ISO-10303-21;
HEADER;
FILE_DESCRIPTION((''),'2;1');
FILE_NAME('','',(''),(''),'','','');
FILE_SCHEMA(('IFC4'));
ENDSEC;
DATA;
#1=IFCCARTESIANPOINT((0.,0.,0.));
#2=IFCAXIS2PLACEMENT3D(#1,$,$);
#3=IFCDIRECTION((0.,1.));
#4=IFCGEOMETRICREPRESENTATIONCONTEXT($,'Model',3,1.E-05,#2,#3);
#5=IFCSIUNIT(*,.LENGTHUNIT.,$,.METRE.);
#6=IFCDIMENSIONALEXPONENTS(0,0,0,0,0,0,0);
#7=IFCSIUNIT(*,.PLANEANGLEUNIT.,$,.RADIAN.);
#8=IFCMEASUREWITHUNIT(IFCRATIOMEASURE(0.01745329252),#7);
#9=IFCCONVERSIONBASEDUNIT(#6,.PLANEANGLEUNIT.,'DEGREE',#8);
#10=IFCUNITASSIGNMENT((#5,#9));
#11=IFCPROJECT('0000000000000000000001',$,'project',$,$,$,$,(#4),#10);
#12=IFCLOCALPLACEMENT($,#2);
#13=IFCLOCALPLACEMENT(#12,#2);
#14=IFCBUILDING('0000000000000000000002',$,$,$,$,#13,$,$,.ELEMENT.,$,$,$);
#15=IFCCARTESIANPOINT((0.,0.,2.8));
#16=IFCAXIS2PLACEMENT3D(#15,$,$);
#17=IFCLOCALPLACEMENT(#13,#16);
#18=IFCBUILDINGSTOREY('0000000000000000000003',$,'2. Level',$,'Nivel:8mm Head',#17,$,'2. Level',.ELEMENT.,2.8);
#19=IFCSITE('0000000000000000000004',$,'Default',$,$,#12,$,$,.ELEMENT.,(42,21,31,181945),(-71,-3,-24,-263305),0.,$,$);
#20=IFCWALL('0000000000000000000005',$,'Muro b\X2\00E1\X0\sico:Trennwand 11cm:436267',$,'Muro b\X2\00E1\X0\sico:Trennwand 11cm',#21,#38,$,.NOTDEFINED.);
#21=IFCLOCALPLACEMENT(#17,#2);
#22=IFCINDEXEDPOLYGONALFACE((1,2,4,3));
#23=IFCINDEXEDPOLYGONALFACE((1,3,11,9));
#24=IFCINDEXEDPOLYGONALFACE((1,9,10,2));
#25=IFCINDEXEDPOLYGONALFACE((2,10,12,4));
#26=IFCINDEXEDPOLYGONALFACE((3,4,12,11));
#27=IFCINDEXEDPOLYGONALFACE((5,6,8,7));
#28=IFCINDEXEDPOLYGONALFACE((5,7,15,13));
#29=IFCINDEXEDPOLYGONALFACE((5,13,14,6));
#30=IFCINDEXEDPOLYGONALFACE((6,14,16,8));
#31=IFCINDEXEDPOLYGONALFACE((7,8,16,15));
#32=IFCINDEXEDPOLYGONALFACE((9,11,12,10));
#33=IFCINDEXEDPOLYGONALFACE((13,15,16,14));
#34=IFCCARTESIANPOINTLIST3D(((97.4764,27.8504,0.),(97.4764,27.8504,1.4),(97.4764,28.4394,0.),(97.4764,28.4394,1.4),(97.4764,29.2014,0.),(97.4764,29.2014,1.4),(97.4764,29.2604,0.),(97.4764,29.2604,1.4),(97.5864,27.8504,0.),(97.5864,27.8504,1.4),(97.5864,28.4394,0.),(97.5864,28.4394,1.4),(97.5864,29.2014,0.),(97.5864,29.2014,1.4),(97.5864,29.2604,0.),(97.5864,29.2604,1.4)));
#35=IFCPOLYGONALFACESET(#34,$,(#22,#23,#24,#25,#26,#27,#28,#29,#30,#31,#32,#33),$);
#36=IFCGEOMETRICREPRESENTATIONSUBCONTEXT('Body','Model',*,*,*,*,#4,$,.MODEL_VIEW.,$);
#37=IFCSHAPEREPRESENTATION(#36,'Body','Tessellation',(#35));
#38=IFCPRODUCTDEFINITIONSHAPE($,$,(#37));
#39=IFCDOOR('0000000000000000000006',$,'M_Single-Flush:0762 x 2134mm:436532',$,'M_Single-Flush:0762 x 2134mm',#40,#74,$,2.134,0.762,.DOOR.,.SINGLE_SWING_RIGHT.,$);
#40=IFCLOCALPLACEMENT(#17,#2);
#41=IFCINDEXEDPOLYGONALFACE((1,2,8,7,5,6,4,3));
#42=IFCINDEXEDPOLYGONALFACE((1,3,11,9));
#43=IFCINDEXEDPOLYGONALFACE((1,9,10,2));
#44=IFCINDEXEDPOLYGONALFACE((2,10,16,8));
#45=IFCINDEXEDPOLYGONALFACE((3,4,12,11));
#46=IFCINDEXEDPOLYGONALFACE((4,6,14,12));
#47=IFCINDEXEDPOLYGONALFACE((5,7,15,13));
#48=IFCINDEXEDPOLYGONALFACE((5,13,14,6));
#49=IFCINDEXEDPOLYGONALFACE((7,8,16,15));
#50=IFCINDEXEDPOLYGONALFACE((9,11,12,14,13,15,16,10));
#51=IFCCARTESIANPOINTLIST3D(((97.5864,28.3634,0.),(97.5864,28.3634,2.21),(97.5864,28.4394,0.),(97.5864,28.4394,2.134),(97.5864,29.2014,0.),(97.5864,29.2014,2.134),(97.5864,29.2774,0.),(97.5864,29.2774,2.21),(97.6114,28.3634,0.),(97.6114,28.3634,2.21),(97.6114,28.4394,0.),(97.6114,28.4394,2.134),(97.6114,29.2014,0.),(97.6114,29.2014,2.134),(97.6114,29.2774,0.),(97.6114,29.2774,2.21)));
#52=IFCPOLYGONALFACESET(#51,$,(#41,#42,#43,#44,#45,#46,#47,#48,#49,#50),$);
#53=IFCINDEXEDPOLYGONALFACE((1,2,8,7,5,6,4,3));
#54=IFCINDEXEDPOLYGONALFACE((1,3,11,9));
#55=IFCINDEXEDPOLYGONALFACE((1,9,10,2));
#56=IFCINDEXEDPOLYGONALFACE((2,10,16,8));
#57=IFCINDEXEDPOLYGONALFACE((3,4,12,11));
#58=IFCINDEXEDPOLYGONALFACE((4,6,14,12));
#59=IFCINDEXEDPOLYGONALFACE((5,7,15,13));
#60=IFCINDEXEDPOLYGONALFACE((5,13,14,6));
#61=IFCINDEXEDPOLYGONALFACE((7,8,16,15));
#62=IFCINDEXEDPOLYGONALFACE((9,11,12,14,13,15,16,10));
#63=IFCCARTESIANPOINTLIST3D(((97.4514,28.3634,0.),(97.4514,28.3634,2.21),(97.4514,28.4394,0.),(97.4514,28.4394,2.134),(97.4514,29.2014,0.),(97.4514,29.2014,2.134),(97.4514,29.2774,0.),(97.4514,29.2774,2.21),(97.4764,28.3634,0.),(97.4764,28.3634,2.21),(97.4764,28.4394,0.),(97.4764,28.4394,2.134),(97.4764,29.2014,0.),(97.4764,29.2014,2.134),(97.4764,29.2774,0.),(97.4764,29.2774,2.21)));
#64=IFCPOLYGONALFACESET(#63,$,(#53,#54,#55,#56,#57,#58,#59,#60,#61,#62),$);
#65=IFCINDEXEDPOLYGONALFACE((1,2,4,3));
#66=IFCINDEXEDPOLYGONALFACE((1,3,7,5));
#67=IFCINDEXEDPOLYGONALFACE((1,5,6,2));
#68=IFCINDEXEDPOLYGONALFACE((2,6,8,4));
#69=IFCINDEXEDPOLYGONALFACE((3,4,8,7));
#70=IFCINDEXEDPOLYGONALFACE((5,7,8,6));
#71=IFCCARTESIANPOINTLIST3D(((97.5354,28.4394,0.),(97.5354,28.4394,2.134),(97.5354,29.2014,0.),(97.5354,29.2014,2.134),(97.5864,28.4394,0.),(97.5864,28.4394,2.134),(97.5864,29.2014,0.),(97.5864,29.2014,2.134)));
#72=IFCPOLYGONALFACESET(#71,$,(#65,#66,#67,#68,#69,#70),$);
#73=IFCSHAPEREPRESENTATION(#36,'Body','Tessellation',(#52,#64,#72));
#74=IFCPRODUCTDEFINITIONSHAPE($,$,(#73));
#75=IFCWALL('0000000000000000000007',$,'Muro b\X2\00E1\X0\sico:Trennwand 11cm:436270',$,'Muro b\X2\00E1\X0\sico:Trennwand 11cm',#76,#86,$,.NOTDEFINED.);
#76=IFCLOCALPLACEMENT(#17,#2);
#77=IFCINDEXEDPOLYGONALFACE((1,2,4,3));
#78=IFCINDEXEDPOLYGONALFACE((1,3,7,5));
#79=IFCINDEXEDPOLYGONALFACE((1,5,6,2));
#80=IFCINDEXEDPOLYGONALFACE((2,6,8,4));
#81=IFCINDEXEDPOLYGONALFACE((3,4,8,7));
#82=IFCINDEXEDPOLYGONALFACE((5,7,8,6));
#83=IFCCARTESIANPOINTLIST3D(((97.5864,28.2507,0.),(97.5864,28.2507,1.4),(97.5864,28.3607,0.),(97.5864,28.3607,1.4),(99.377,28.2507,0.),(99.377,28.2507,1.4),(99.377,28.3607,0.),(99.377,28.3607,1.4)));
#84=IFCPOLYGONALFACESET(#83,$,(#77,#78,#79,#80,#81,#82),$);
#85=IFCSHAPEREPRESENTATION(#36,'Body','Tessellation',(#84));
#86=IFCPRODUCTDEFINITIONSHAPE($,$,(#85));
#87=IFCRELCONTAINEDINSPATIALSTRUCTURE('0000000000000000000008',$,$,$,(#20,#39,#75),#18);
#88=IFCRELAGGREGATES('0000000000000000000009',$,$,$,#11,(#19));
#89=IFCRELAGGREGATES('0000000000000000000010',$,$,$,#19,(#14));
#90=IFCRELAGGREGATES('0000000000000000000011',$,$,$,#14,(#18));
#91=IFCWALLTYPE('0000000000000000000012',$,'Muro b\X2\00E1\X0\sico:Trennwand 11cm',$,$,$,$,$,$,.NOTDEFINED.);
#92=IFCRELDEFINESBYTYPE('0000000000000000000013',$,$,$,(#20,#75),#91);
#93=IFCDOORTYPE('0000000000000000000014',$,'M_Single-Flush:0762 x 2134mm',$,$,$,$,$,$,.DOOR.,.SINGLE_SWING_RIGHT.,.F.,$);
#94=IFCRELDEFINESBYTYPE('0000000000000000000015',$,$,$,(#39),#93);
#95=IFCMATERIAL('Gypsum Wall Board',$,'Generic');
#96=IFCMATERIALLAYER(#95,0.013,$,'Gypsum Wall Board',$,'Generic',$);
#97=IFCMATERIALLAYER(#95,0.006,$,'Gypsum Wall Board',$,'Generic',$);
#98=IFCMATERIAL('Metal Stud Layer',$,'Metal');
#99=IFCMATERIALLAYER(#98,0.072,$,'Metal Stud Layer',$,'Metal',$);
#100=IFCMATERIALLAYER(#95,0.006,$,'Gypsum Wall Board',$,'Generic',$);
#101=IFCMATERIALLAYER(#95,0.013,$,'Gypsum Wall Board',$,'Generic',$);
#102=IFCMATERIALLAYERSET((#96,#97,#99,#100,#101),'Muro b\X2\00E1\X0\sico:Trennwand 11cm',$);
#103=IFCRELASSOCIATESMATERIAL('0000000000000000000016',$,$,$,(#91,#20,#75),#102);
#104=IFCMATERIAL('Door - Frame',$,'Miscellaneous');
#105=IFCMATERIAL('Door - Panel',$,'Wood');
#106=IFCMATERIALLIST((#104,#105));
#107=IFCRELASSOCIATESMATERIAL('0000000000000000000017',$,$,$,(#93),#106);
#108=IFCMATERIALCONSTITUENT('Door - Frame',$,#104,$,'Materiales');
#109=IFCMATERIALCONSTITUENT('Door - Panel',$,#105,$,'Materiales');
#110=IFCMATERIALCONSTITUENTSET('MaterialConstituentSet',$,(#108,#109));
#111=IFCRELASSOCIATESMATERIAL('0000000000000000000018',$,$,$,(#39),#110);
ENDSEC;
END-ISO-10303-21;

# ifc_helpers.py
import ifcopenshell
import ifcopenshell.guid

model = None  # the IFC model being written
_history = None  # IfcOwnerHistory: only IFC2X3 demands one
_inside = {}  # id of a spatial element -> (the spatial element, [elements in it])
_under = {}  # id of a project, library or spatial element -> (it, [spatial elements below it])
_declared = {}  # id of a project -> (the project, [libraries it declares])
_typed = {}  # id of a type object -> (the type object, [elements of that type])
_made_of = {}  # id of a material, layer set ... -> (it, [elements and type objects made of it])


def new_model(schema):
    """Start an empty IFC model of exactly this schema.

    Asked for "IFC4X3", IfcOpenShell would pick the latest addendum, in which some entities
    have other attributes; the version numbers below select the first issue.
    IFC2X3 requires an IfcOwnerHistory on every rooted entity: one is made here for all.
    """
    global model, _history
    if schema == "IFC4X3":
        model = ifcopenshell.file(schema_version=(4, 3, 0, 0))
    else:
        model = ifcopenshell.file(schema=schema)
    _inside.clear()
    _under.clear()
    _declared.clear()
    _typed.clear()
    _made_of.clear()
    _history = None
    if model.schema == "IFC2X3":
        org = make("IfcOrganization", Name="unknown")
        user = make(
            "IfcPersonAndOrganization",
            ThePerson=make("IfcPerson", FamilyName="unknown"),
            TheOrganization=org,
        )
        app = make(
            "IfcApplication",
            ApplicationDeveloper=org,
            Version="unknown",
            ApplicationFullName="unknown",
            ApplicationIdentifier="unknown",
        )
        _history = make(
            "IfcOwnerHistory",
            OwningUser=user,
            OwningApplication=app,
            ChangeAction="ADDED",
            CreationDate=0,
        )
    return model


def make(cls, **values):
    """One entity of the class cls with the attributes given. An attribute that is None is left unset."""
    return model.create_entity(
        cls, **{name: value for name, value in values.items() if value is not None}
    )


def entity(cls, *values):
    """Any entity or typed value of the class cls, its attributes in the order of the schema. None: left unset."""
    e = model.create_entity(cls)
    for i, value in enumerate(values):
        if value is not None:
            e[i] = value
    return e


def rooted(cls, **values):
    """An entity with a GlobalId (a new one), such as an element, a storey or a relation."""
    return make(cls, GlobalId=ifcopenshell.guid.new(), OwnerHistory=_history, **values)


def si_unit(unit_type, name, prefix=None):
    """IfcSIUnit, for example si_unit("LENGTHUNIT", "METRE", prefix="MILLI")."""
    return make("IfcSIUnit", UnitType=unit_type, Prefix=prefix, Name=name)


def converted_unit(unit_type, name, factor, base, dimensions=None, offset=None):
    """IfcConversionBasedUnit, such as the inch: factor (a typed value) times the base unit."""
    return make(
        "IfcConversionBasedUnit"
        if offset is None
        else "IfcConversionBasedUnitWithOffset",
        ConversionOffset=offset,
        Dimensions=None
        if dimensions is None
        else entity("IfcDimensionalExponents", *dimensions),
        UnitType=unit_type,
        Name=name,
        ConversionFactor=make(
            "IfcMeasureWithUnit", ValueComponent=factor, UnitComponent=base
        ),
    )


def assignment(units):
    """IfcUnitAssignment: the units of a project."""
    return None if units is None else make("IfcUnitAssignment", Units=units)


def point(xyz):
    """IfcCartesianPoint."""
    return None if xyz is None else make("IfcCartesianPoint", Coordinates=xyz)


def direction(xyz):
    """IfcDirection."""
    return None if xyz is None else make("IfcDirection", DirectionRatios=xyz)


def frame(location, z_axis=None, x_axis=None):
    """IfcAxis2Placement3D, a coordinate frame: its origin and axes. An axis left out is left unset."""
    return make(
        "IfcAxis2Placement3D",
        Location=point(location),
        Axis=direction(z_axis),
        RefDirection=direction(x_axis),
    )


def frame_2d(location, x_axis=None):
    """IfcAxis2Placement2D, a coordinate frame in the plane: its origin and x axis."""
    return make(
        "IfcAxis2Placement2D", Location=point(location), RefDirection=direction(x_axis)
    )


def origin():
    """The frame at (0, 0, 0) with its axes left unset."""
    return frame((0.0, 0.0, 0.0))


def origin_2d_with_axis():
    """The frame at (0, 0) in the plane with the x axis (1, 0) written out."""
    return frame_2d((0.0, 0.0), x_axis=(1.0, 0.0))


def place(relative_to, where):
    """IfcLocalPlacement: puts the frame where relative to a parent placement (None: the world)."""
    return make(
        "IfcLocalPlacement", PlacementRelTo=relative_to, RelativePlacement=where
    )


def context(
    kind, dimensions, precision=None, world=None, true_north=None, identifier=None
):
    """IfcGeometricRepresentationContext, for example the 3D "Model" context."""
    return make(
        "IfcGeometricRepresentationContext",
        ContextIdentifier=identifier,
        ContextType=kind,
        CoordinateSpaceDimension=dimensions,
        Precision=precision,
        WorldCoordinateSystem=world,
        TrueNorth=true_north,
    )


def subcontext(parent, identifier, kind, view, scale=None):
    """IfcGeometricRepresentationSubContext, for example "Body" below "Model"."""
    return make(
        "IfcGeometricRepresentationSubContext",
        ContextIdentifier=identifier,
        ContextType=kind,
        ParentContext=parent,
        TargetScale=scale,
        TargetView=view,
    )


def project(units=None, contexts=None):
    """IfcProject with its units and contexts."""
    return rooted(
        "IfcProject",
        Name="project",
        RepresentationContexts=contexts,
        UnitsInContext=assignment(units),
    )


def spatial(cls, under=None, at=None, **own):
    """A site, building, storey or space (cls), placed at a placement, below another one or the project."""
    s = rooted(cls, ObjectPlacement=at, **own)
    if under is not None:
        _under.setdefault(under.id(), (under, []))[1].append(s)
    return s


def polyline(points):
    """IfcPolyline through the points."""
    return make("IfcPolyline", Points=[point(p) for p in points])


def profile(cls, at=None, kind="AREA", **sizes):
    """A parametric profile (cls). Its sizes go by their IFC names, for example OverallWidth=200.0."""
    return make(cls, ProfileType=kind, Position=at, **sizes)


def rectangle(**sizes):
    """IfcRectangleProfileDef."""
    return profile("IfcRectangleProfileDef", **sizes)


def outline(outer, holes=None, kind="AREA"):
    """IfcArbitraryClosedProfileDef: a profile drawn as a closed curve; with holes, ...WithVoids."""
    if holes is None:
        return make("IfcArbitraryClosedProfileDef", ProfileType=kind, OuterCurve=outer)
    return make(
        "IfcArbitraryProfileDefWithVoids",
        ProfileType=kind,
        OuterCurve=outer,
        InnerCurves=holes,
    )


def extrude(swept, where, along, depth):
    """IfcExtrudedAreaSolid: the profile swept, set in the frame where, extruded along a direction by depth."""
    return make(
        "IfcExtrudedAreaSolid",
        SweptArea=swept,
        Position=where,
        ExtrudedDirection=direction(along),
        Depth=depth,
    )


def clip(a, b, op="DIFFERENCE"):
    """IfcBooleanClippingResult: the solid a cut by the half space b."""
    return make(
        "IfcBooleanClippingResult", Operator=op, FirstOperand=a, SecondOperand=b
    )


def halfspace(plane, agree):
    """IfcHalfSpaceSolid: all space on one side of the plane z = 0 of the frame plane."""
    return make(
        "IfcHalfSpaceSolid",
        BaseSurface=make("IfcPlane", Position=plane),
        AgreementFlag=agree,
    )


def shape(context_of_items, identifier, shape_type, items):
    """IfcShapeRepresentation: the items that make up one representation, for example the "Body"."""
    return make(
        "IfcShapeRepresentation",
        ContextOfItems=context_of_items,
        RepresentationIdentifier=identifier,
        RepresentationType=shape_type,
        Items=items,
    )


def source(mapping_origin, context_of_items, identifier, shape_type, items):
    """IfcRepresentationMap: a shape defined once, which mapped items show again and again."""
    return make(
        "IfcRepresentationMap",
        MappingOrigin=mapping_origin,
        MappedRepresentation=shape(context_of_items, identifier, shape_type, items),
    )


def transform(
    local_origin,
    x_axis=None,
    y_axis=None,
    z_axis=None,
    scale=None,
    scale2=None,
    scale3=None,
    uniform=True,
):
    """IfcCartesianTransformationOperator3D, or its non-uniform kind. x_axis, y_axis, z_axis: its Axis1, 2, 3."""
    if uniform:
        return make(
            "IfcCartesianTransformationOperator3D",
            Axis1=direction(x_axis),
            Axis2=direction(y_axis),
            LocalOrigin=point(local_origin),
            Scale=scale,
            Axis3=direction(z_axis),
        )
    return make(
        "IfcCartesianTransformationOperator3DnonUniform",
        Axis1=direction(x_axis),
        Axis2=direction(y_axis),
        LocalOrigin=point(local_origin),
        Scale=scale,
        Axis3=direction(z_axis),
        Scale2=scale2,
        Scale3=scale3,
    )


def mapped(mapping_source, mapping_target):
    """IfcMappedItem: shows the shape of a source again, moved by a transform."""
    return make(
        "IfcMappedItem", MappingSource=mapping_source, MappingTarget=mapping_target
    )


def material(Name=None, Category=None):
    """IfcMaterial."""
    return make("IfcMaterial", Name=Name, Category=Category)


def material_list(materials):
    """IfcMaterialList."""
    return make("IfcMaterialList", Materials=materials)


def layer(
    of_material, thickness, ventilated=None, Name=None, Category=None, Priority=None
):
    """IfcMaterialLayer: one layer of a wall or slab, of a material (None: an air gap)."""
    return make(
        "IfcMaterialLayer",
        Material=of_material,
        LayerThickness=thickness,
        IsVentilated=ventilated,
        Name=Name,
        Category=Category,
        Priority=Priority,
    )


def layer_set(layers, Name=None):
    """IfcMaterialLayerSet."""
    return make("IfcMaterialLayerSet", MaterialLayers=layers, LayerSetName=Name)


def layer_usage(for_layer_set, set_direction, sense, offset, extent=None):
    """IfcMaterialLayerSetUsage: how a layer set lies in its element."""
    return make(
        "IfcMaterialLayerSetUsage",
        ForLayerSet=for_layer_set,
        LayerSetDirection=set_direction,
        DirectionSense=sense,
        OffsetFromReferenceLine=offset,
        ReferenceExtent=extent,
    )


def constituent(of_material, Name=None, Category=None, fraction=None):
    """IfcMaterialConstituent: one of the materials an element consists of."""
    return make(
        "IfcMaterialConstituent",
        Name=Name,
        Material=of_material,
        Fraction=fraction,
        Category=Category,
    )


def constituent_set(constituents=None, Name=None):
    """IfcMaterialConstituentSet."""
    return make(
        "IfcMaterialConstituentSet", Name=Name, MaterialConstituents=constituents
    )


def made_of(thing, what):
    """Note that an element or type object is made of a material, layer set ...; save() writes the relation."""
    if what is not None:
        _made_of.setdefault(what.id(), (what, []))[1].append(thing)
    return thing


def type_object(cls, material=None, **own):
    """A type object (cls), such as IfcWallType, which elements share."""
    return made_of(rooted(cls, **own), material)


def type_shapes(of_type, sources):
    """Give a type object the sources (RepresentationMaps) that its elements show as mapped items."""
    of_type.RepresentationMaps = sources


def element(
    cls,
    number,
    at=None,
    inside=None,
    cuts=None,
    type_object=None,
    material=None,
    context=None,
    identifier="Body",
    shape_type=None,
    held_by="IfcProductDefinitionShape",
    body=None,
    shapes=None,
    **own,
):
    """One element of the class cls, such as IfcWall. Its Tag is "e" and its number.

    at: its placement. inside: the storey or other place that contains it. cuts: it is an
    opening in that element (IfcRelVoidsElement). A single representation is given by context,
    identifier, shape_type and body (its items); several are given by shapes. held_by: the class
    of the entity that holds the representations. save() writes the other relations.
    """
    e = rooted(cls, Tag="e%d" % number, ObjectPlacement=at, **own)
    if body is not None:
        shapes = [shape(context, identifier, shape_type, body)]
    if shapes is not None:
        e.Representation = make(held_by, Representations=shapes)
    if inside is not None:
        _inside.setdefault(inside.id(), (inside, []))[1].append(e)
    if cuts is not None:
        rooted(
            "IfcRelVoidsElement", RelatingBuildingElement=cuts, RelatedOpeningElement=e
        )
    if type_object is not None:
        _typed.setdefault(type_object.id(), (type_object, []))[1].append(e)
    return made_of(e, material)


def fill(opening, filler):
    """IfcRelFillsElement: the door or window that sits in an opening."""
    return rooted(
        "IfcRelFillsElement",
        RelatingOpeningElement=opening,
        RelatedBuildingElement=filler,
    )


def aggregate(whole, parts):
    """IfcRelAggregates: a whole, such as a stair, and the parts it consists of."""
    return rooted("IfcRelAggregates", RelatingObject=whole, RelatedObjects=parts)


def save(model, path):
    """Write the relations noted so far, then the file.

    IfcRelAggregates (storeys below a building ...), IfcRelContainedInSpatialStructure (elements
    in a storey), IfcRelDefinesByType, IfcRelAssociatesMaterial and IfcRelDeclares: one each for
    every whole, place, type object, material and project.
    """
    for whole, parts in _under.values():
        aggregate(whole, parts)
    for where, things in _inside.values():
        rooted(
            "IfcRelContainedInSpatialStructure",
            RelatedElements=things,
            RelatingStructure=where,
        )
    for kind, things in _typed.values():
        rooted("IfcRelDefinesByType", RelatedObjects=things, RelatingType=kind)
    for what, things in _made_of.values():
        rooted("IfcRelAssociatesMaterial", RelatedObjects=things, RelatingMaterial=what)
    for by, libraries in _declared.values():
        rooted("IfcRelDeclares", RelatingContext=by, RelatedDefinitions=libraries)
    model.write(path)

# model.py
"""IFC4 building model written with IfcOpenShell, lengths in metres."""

from ifc_helpers import new_model, entity, si_unit, converted_unit, direction, frame, frame_2d, origin, origin_2d_with_axis, place, context, subcontext, project, spatial, polyline, rectangle, outline, extrude, clip, halfspace, source, transform, mapped, material, material_list, layer, layer_set, layer_usage, constituent, constituent_set, type_object, type_shapes, element, fill, save


model = new_model("IFC4")

# Units and contexts
model_context = context("Model", 3, precision=1e-05, world=origin(), true_north=direction((0.0, 1.0)))
body_context = subcontext(model_context, "Body", "Model", "MODEL_VIEW")
ifc_project = project(units=[si_unit("LENGTHUNIT", "METRE"), converted_unit("PLANEANGLEUNIT", "DEGREE", entity("IfcRatioMeasure", 0.01745329252), si_unit("PLANEANGLEUNIT", "RADIAN"), dimensions=[0, 0, 0, 0, 0, 0, 0])], contexts=[model_context])

# Site, building, storey
site_placement = place(None, origin())
site = spatial("IfcSite", under=ifc_project, at=site_placement, Name="Default", CompositionType="ELEMENT", RefLatitude=(42, 21, 31, 181945), RefLongitude=(-71, -3, -24, -263305), RefElevation=0.0)
building_placement = place(site_placement, origin())
building = spatial("IfcBuilding", under=site, at=building_placement, CompositionType="ELEMENT")
storey_placement = place(building_placement, frame((0.0, 0.0, 2.8)))
storey = spatial("IfcBuildingStorey", under=building, at=storey_placement, Name="2. Level", ObjectType="Nivel:8mm Head", LongName="2. Level", CompositionType="ELEMENT", Elevation=2.8)

# Shared definitions
ifc_material_1 = material(Name="Gypsum Wall Board", Category="Generic")
ifc_layer_1 = layer(ifc_material_1, 0.013, Name="Gypsum Wall Board", Category="Generic")
ifc_layer_2 = layer(ifc_material_1, 0.006, Name="Gypsum Wall Board", Category="Generic")
ifc_material_2 = material(Name="Metal Stud Layer", Category="Metal")
ifc_layer_3 = layer(ifc_material_2, 0.072, Name="Metal Stud Layer", Category="Metal")
ifc_layer_4 = layer(ifc_material_1, 0.006, Name="Gypsum Wall Board", Category="Generic")
ifc_layer_5 = layer(ifc_material_1, 0.013, Name="Gypsum Wall Board", Category="Generic")
ifc_layer_set_1 = layer_set([ifc_layer_1, ifc_layer_2, ifc_layer_3, ifc_layer_4, ifc_layer_5], Name="Muro básico:Trennwand 11cm")
wall_type_1 = type_object("IfcWallType", Name="Muro básico:Trennwand 11cm", PredefinedType="NOTDEFINED", material=ifc_layer_set_1)

# Shared definitions
ifc_material_3 = material(Name="Door - Frame", Category="Miscellaneous")
ifc_material_4 = material(Name="Door - Panel", Category="Wood")
ifc_material_list_1 = material_list([ifc_material_3, ifc_material_4])
door_type = type_object("IfcDoorType", Name="M_Single-Flush:0762 x 2134mm", OperationType="SINGLE_SWING_RIGHT", ParameterTakesPrecedence=False, PredefinedType="DOOR", material=ifc_material_list_1)
shared_shape_1 = source(origin(), body_context, "Body", "SweptSolid", [
    extrude(outline(polyline([(-0.457, -1.124), (0.457, -1.124), (0.457, 1.086), (0.381, 1.086), (0.381, -1.048), (-0.381, -1.048), (-0.381, 1.086), (-0.457, 1.086), (-0.457, -1.124)])), frame((0.381, 0.11, 1.086), z_axis=(0.0, 1.0, 0.0), x_axis=(1.0, 0.0, 0.0)), (0.0, 0.0, 1.0), 0.025),
    extrude(outline(polyline([(-1.124, -0.457), (1.086, -0.457), (1.086, -0.381), (-1.048, -0.381), (-1.048, 0.381), (1.086, 0.381), (1.086, 0.457), (-1.124, 0.457), (-1.124, -0.457)])), frame((0.381, -0.025, 1.086), z_axis=(0.0, 1.0, 0.0), x_axis=(0.0, 0.0, -1.0)), (0.0, 0.0, 1.0), 0.025),
    extrude(rectangle(XDim=0.051, YDim=0.762, at=origin_2d_with_axis()), frame((0.381, 0.0845, 0.0), z_axis=(0.0, 0.0, 1.0), x_axis=(0.0, 1.0, 0.0)), (0.0, 0.0, 1.0), 2.134),
])
type_shapes(door_type, [shared_shape_1])

# Wall, opening, door
ifc_layer_usage_1 = layer_usage(ifc_layer_set_1, "AXIS2", "NEGATIVE", 0.055)
wall_1_placement = place(storey_placement, frame((97.5314, 29.2604, 0.0), z_axis=(0.0, 0.0, 1.0), x_axis=(0.0, -1.0, 0.0)))
wall_1 = element("IfcWall", 1, at=wall_1_placement, inside=storey, type_object=wall_type_1, material=ifc_layer_usage_1, Name="Muro básico:Trennwand 11cm:436267", ObjectType="Muro básico:Trennwand 11cm", PredefinedType="NOTDEFINED", context=body_context, shape_type="Clipping", body=[
    clip(extrude(rectangle(XDim=1.41, YDim=0.11, at=frame_2d((0.705, 0.0), x_axis=(-1.0, 0.0))), origin(), (0.0, 0.0, 1.0), 1.4), halfspace(origin(), True)),
])
opening_1_placement = place(wall_1_placement, frame((0.059, -0.055, 0.0)))
opening_1 = element("IfcOpeningElement", 2, at=opening_1_placement, cuts=wall_1, ObjectType="Opening", PredefinedType="OPENING", context=body_context, shape_type="SweptSolid", body=[
    extrude(rectangle(XDim=0.762, YDim=2.134, at=frame_2d((1.067, 0.381), x_axis=(0.0, 1.0))), frame((0.0, 0.0, 0.0), z_axis=(0.0, 1.0, 0.0), x_axis=(0.0, 0.0, 1.0)), (0.0, 0.0, 1.0), 0.11),
])
ifc_constituent_1 = constituent(ifc_material_3, Name="Door - Frame", Category="Materiales")
ifc_constituent_2 = constituent(ifc_material_4, Name="Door - Panel", Category="Materiales")
ifc_constituent_set_1 = constituent_set(constituents=[ifc_constituent_1, ifc_constituent_2], Name="MaterialConstituentSet")
door_1_placement = place(opening_1_placement, origin())
door_1 = element("IfcDoor", 3, at=door_1_placement, inside=storey, type_object=door_type, material=ifc_constituent_set_1, Name="M_Single-Flush:0762 x 2134mm:436532", ObjectType="M_Single-Flush:0762 x 2134mm", OperationType="SINGLE_SWING_RIGHT", OverallHeight=2.134, OverallWidth=0.762, PredefinedType="DOOR", context=body_context, shape_type="MappedRepresentation", body=[
    mapped(shared_shape_1, transform((0.0, 0.0, 0.0), scale=1.0)),
])
fill(opening_1, door_1)

# Wall
ifc_layer_usage_2 = layer_usage(ifc_layer_set_1, "AXIS2", "NEGATIVE", 0.055)
wall_2_placement = place(storey_placement, frame((99.377, 28.3057, 0.0), z_axis=(0.0, 0.0, 1.0), x_axis=(-1.0, 0.0, 0.0)))
element("IfcWall", 4, at=wall_2_placement, inside=storey, type_object=wall_type_1, material=ifc_layer_usage_2, Name="Muro básico:Trennwand 11cm:436270", ObjectType="Muro básico:Trennwand 11cm", PredefinedType="NOTDEFINED", context=body_context, shape_type="Clipping", body=[
    clip(extrude(rectangle(XDim=1.7906, YDim=0.11, at=frame_2d((0.8953, 0.0), x_axis=(-1.0, 0.0))), origin(), (0.0, 0.0, 1.0), 1.4), halfspace(origin(), True)),
])

save(model, "model.ifc")
